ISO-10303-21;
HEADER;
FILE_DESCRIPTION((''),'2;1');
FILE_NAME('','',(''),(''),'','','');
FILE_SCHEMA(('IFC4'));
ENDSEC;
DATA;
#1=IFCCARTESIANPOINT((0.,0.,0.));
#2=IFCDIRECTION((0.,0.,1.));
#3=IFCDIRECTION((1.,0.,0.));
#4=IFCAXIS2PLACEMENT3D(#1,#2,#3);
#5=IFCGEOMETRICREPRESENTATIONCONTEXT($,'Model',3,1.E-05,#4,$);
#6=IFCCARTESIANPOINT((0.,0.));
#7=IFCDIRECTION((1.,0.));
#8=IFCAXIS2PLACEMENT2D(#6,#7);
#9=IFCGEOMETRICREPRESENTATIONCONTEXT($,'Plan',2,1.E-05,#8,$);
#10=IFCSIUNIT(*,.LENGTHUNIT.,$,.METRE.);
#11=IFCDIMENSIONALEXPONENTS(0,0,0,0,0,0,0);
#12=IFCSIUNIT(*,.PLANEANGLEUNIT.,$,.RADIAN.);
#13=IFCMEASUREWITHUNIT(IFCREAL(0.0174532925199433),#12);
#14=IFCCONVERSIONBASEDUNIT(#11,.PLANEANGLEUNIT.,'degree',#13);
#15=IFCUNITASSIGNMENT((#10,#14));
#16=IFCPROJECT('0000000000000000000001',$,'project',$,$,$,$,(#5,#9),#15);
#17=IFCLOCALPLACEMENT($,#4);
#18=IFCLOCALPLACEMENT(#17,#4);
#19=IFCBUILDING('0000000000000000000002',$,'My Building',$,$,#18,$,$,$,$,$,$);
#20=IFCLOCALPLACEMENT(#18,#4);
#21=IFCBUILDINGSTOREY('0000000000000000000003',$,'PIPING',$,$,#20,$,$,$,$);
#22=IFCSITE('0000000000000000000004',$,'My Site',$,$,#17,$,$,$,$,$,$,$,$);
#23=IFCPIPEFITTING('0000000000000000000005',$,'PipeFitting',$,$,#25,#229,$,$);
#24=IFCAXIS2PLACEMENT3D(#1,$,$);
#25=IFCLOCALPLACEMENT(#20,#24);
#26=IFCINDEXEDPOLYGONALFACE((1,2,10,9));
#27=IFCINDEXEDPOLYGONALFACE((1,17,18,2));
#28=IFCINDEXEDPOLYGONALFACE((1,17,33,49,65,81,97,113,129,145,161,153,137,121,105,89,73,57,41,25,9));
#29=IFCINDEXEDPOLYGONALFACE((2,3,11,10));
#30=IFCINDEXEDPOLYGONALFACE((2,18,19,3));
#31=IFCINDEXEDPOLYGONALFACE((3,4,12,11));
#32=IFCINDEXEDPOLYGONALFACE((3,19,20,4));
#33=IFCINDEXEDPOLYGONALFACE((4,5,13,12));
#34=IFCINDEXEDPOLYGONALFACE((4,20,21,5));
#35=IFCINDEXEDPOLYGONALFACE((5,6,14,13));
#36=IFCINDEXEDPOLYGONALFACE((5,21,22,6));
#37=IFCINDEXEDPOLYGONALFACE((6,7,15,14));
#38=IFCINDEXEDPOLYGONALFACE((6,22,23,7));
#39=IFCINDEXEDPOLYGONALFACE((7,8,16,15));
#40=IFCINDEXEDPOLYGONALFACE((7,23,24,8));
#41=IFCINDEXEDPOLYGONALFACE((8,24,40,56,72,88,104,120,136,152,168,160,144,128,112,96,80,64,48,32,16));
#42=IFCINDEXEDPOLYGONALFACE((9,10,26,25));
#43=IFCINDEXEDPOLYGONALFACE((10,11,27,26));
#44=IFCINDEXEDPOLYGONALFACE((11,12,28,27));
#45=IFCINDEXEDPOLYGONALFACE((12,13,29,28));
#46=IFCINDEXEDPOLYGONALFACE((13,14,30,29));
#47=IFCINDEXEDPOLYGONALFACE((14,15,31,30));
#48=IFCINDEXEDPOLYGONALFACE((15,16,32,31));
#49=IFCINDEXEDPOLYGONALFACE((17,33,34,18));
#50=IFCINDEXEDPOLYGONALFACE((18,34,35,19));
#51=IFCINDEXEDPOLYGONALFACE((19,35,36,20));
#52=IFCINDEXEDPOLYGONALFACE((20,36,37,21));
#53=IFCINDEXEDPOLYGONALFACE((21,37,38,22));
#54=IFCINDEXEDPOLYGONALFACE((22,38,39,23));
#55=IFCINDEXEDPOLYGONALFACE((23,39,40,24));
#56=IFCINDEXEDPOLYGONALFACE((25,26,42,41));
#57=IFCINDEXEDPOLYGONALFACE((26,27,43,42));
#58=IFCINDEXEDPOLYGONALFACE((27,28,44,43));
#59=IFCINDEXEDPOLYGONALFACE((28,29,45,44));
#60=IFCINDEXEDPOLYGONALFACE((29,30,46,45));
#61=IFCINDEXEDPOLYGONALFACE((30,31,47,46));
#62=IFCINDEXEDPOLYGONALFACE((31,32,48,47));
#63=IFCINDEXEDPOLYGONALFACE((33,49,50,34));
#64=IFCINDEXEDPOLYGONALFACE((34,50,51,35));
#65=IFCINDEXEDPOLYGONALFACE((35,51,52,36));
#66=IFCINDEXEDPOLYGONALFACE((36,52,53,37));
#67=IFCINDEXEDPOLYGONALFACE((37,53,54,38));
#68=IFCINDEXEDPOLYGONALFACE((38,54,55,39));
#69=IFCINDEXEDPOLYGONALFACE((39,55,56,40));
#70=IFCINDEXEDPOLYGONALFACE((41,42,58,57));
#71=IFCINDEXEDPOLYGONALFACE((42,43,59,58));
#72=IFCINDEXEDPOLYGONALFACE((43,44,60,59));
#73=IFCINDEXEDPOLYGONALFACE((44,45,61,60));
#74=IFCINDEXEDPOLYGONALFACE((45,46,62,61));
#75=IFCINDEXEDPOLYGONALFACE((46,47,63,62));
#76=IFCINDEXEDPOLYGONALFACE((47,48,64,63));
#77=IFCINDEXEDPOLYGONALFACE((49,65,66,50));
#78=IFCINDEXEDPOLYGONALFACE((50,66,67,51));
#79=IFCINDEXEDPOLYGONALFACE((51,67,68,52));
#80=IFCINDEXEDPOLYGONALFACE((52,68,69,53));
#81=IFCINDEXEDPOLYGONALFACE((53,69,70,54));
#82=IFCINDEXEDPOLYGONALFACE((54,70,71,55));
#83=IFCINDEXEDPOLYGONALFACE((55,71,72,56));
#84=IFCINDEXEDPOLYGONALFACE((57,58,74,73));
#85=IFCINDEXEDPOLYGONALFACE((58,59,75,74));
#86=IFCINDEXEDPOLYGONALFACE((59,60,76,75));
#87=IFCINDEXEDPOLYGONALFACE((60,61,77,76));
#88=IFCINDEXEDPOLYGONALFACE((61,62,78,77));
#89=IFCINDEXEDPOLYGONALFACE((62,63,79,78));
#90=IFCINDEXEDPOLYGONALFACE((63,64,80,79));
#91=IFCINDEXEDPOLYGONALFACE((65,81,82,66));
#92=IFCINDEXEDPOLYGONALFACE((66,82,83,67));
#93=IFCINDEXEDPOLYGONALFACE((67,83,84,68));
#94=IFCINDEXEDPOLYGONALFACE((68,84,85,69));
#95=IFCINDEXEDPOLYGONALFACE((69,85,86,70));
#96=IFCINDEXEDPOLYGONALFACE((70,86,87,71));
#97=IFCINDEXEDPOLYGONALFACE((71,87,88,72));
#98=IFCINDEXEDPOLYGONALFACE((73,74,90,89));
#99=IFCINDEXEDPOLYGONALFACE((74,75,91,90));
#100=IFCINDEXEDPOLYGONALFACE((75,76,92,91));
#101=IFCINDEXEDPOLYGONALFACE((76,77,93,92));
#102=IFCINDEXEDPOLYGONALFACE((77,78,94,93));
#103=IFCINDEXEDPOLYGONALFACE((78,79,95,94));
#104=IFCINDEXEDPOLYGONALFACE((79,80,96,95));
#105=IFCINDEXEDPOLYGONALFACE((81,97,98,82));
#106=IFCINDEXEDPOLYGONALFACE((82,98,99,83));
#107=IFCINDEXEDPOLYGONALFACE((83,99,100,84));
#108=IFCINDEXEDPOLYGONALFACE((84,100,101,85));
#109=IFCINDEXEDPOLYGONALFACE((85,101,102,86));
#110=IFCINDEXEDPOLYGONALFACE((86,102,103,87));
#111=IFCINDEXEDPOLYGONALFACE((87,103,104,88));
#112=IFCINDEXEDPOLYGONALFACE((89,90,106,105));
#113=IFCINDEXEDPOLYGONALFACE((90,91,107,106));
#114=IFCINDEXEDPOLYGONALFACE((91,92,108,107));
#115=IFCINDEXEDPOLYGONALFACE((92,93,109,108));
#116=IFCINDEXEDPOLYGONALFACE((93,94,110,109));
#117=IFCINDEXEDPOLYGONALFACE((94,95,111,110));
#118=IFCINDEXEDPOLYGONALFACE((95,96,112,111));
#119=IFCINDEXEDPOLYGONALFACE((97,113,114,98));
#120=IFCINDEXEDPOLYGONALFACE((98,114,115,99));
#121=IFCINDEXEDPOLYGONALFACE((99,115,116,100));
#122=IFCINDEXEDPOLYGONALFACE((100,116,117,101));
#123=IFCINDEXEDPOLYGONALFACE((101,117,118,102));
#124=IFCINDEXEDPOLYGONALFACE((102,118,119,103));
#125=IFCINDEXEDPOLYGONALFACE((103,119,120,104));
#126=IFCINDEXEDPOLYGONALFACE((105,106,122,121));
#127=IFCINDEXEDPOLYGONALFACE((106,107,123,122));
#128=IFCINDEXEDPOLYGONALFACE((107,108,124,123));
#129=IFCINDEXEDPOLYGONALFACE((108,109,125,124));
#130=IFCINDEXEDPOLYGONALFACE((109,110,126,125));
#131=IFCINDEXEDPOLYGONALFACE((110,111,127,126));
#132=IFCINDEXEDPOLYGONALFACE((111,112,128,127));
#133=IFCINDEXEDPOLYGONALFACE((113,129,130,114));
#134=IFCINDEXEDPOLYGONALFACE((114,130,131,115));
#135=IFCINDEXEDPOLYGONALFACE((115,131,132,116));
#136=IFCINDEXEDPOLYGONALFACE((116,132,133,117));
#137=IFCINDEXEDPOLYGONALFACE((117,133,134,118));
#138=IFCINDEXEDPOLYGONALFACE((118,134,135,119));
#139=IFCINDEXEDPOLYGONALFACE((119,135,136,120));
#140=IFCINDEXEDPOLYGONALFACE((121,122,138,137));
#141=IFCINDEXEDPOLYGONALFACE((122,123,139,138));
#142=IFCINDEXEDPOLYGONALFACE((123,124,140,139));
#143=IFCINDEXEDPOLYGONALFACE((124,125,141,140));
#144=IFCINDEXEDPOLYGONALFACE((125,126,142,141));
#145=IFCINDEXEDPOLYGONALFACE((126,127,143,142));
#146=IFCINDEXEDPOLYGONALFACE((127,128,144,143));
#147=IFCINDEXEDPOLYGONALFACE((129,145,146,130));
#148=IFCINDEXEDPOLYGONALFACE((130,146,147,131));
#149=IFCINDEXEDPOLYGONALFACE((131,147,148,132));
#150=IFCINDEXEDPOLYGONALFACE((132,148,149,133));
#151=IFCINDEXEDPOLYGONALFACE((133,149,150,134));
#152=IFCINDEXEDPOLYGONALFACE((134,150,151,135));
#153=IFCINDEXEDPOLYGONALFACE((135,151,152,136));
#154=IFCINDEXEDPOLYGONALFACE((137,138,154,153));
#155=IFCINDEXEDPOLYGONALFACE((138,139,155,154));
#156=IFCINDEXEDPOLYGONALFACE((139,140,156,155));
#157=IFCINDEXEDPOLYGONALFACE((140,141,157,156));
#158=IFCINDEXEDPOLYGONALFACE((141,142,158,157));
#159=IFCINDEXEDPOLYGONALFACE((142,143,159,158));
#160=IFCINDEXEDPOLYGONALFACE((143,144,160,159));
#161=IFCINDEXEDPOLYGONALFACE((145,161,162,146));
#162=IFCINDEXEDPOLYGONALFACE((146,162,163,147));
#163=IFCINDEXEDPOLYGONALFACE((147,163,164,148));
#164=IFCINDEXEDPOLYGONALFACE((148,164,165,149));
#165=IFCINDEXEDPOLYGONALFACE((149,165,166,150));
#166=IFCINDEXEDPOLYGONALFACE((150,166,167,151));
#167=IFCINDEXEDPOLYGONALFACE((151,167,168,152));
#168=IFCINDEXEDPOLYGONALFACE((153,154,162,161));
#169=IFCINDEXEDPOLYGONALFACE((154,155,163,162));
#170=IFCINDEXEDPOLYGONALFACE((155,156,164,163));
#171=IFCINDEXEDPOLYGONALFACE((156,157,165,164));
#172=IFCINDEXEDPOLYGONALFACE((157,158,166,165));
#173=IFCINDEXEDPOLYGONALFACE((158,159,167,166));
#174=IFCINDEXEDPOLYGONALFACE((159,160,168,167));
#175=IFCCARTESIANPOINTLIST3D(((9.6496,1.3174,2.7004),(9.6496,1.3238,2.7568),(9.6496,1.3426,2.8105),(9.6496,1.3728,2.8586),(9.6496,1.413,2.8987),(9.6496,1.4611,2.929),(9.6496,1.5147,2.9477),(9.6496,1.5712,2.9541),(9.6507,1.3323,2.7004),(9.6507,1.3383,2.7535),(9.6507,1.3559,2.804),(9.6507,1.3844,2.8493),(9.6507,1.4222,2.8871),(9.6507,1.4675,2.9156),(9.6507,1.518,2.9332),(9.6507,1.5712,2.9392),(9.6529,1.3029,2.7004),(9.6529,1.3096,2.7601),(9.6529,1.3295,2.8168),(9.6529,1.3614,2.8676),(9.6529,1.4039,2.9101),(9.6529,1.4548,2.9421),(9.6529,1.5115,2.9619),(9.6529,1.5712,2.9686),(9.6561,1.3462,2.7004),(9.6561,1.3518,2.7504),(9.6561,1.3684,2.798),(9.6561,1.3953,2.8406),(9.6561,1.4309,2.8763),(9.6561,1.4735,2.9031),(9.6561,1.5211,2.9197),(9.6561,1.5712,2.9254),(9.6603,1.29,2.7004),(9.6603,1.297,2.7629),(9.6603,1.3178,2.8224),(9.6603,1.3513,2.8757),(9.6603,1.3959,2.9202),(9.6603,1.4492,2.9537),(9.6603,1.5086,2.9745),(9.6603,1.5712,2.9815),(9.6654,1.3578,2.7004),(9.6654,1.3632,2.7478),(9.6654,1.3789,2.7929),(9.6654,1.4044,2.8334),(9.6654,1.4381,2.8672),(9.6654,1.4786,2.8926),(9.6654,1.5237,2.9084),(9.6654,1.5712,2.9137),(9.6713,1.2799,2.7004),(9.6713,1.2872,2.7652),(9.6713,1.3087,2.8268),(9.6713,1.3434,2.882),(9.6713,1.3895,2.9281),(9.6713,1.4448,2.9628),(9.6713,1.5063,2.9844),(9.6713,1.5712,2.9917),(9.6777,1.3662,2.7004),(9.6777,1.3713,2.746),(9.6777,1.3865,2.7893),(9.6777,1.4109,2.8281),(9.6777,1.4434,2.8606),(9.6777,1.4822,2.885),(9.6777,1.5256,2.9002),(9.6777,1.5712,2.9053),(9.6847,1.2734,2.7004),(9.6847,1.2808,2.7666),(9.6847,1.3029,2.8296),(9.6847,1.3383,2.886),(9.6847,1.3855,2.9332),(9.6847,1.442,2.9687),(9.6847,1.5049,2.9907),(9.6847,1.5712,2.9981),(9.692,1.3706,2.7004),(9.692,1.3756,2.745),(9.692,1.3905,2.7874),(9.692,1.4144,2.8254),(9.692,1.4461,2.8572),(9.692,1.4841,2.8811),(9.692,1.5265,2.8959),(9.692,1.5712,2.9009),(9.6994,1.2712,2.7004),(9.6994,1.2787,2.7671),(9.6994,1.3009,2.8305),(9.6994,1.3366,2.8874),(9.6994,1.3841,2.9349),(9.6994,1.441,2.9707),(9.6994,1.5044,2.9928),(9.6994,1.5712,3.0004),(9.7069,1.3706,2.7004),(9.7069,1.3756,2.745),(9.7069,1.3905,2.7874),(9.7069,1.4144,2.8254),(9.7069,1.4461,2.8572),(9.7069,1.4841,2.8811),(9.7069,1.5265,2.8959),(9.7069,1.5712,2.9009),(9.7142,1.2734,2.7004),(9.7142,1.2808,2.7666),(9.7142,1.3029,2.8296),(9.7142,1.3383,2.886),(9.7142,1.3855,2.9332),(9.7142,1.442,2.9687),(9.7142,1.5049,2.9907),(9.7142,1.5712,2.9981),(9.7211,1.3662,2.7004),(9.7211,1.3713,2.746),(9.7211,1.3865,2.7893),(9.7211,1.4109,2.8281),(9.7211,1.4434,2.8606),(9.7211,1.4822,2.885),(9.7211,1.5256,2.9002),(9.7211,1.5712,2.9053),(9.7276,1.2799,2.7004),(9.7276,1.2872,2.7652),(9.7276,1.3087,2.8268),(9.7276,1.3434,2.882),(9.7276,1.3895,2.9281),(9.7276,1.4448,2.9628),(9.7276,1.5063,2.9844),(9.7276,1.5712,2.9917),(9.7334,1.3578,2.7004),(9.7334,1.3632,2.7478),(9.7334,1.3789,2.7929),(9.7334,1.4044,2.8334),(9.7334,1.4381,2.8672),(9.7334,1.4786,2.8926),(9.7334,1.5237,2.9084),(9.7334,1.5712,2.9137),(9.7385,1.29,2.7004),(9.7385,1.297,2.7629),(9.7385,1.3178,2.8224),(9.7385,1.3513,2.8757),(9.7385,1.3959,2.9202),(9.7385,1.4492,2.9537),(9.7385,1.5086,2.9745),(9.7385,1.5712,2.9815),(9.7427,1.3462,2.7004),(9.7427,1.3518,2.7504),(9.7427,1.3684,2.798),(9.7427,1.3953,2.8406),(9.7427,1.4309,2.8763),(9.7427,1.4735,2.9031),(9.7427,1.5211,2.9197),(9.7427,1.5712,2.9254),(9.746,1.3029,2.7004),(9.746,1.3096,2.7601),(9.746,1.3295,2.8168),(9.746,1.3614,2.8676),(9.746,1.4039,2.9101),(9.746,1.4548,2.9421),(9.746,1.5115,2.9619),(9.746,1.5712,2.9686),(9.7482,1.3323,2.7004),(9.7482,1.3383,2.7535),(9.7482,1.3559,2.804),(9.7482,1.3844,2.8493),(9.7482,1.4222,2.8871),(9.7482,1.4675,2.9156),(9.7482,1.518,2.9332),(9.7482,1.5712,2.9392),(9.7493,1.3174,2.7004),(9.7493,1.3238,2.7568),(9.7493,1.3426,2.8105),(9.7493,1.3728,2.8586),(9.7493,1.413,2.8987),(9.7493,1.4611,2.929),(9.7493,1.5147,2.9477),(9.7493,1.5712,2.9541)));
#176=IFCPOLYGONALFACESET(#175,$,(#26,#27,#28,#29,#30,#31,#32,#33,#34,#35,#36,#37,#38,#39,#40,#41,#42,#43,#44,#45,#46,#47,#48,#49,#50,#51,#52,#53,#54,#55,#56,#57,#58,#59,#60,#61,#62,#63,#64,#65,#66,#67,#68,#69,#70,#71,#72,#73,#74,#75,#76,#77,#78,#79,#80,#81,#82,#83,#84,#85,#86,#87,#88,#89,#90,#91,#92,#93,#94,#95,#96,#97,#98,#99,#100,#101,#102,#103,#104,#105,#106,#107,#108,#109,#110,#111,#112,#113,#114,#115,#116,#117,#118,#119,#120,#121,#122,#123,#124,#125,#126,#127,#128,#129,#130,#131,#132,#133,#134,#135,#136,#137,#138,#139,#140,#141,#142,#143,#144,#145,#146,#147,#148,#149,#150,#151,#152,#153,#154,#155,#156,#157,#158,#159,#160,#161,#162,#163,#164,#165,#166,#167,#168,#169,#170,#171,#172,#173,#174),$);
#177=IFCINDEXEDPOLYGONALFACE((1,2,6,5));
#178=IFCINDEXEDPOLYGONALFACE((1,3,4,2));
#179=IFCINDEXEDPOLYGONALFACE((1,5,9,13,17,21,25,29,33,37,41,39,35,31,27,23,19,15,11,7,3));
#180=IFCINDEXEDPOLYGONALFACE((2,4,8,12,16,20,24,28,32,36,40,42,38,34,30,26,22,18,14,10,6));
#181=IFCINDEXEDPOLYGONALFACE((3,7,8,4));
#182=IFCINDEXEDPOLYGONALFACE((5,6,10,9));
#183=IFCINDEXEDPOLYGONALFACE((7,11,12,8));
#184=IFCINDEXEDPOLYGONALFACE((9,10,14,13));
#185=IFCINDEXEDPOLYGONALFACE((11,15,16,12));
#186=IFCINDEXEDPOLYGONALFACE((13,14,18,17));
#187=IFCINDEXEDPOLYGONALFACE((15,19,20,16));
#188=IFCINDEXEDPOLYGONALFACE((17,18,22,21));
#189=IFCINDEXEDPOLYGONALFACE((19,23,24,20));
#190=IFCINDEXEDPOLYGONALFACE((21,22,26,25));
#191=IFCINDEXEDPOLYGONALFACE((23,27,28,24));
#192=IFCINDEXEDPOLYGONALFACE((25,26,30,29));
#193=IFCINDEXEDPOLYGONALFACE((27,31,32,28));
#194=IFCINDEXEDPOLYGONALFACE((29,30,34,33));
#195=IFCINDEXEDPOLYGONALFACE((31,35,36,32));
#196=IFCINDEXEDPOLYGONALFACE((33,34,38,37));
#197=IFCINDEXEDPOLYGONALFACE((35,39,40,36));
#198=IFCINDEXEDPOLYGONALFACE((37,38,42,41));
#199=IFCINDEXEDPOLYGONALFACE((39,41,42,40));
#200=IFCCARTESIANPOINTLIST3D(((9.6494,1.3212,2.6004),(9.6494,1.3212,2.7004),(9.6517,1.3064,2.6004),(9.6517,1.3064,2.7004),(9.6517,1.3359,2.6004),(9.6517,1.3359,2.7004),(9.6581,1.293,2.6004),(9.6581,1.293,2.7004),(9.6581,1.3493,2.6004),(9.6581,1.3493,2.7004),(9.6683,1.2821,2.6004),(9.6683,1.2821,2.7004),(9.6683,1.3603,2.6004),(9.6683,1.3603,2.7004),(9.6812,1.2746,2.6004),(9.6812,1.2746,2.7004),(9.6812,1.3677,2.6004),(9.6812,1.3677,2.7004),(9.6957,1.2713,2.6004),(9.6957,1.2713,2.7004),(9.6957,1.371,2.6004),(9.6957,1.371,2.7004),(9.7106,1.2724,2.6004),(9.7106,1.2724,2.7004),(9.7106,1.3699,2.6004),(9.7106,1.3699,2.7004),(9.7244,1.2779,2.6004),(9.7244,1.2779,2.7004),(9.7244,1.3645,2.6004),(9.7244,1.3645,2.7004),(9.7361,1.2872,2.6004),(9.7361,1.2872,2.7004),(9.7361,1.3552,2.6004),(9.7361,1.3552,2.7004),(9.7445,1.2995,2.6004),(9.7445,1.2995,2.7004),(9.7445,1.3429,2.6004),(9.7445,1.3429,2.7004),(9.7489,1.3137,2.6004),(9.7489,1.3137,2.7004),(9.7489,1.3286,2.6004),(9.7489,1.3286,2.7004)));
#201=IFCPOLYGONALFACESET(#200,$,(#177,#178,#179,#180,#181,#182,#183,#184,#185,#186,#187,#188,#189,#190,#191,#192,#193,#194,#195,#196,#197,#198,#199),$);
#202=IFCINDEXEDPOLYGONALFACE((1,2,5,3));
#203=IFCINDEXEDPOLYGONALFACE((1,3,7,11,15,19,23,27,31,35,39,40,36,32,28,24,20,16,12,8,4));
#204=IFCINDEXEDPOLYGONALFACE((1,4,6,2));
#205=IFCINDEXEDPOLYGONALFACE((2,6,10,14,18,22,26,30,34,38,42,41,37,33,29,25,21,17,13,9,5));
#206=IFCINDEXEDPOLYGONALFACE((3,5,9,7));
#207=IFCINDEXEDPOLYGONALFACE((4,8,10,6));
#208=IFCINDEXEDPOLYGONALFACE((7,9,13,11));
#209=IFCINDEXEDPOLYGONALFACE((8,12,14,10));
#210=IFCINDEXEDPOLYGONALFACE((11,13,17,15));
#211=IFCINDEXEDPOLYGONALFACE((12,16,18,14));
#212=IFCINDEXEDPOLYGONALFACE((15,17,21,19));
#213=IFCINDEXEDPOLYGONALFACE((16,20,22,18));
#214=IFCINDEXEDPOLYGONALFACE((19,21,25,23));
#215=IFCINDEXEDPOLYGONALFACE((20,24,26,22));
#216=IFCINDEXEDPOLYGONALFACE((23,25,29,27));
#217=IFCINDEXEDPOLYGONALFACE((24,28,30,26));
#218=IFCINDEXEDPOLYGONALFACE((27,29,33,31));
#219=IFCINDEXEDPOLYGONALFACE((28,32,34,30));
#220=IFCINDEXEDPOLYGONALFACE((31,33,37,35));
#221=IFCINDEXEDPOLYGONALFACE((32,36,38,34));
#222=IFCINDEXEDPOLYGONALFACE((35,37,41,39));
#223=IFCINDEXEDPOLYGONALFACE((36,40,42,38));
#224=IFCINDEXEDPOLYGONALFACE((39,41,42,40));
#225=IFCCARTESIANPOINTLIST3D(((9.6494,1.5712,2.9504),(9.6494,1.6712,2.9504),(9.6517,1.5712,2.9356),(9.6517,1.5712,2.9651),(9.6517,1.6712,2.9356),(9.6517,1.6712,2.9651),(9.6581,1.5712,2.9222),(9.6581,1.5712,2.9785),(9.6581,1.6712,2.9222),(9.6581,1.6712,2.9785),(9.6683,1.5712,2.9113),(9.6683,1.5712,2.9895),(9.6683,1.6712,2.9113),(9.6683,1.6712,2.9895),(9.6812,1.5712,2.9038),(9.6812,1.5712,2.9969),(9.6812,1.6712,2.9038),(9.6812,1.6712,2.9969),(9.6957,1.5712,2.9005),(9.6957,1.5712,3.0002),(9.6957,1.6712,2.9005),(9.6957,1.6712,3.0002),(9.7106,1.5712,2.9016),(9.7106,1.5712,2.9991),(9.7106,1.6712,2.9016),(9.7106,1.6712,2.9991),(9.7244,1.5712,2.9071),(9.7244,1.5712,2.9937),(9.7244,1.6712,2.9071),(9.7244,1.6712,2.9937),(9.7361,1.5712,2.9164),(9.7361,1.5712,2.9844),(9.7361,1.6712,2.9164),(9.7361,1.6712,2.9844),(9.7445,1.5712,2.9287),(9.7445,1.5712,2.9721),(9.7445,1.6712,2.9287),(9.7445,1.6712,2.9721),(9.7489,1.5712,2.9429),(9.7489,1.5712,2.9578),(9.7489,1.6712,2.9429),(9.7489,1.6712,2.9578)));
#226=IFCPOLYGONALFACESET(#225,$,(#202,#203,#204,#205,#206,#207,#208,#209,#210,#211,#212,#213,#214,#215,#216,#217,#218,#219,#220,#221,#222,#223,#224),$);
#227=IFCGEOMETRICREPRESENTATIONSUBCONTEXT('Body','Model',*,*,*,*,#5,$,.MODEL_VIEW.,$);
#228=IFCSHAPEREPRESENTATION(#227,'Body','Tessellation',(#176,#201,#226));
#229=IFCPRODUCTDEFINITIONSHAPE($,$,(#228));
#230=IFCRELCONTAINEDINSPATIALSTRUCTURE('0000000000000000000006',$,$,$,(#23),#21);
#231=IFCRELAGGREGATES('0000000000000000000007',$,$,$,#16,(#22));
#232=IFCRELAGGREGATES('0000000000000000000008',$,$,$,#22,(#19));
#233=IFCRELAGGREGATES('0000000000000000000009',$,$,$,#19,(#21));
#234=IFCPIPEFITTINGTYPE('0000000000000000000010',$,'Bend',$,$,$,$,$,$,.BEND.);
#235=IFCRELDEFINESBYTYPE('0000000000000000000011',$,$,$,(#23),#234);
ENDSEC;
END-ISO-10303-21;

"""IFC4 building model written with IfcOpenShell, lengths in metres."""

from ifc_helpers import new_model, entity, si_unit, converted_unit, frame, origin_with_axes, origin_2d_with_axis, place, context, subcontext, project, spatial, circle, extrude, source, transform, mapped, type_object, type_shapes, element, save


model = new_model("IFC4")

# Units and contexts
model_context = context("Model", 3, precision=1e-05, world=origin_with_axes())
plan_context = context("Plan", 2, precision=1e-05, world=origin_2d_with_axis())
body_context = subcontext(model_context, "Body", "Model", "MODEL_VIEW")
ifc_project = project(units=[si_unit("LENGTHUNIT", "METRE"), converted_unit("PLANEANGLEUNIT", "degree", entity("IfcReal", 0.0174532925199433), si_unit("PLANEANGLEUNIT", "RADIAN"), dimensions=[0, 0, 0, 0, 0, 0, 0])], contexts=[model_context, plan_context])

# Site, building, storey
site_placement = place(None, origin_with_axes())
site = spatial("IfcSite", under=ifc_project, at=site_placement, Name="My Site")
building_placement = place(site_placement, origin_with_axes())
building = spatial("IfcBuilding", under=site, at=building_placement, Name="My Building")
storey_placement = place(building_placement, origin_with_axes())
storey = spatial("IfcBuildingStorey", under=building, at=storey_placement, Name="PIPING")

# Pipe fitting
pipe_fitting_type_1 = type_object("IfcPipeFittingType", Name="Bend", PredefinedType="BEND")
shared_shape = source(origin_with_axes(), body_context, "Body", "SolidModel", [
    entity("IfcSweptDiskSolid", entity("IfcIndexedPolyCurve", entity("IfcCartesianPointList3D", [[0.0, 0.0, -0.1], [0.0, 0.0732, -0.2768], [0.0, 0.25, -0.35]]), [entity("IfcArcIndex", [1, 2, 3])]), 0.05),
    extrude(circle(Radius=0.05), origin_with_axes(), (0.0, 0.0, -1.0), 0.1),
    extrude(circle(Radius=0.05), frame((0.0, 0.25, -0.35), z_axis=(0.0, 1.0, 0.0), x_axis=(1.0, 0.0, 0.0)), (0.0, 0.0, 1.0), 0.1),
])
type_shapes(pipe_fitting_type_1, [shared_shape])
for number, where, z_axis, x_axis, name in (
    (1, (9.6994, 1.3212, 2.6004), (0.0, 0.0, -1.0), (-1.0, 0.0, 0.0), "PipeFitting"),
):
    element("IfcPipeFitting", number, at=place(storey_placement, frame(where, z_axis=z_axis, x_axis=x_axis)), inside=storey, type_object=pipe_fitting_type_1, Name=name, context=body_context, shape_type="MappedRepresentation", body=[
        mapped(shared_shape, transform((0.0, 0.0, 0.0), x_axis=(1.0, 0.0, 0.0), y_axis=(0.0, 1.0, 0.0), z_axis=(0.0, 0.0, 1.0), scale=1.0)),
    ])

save(model, "model.ifc")
